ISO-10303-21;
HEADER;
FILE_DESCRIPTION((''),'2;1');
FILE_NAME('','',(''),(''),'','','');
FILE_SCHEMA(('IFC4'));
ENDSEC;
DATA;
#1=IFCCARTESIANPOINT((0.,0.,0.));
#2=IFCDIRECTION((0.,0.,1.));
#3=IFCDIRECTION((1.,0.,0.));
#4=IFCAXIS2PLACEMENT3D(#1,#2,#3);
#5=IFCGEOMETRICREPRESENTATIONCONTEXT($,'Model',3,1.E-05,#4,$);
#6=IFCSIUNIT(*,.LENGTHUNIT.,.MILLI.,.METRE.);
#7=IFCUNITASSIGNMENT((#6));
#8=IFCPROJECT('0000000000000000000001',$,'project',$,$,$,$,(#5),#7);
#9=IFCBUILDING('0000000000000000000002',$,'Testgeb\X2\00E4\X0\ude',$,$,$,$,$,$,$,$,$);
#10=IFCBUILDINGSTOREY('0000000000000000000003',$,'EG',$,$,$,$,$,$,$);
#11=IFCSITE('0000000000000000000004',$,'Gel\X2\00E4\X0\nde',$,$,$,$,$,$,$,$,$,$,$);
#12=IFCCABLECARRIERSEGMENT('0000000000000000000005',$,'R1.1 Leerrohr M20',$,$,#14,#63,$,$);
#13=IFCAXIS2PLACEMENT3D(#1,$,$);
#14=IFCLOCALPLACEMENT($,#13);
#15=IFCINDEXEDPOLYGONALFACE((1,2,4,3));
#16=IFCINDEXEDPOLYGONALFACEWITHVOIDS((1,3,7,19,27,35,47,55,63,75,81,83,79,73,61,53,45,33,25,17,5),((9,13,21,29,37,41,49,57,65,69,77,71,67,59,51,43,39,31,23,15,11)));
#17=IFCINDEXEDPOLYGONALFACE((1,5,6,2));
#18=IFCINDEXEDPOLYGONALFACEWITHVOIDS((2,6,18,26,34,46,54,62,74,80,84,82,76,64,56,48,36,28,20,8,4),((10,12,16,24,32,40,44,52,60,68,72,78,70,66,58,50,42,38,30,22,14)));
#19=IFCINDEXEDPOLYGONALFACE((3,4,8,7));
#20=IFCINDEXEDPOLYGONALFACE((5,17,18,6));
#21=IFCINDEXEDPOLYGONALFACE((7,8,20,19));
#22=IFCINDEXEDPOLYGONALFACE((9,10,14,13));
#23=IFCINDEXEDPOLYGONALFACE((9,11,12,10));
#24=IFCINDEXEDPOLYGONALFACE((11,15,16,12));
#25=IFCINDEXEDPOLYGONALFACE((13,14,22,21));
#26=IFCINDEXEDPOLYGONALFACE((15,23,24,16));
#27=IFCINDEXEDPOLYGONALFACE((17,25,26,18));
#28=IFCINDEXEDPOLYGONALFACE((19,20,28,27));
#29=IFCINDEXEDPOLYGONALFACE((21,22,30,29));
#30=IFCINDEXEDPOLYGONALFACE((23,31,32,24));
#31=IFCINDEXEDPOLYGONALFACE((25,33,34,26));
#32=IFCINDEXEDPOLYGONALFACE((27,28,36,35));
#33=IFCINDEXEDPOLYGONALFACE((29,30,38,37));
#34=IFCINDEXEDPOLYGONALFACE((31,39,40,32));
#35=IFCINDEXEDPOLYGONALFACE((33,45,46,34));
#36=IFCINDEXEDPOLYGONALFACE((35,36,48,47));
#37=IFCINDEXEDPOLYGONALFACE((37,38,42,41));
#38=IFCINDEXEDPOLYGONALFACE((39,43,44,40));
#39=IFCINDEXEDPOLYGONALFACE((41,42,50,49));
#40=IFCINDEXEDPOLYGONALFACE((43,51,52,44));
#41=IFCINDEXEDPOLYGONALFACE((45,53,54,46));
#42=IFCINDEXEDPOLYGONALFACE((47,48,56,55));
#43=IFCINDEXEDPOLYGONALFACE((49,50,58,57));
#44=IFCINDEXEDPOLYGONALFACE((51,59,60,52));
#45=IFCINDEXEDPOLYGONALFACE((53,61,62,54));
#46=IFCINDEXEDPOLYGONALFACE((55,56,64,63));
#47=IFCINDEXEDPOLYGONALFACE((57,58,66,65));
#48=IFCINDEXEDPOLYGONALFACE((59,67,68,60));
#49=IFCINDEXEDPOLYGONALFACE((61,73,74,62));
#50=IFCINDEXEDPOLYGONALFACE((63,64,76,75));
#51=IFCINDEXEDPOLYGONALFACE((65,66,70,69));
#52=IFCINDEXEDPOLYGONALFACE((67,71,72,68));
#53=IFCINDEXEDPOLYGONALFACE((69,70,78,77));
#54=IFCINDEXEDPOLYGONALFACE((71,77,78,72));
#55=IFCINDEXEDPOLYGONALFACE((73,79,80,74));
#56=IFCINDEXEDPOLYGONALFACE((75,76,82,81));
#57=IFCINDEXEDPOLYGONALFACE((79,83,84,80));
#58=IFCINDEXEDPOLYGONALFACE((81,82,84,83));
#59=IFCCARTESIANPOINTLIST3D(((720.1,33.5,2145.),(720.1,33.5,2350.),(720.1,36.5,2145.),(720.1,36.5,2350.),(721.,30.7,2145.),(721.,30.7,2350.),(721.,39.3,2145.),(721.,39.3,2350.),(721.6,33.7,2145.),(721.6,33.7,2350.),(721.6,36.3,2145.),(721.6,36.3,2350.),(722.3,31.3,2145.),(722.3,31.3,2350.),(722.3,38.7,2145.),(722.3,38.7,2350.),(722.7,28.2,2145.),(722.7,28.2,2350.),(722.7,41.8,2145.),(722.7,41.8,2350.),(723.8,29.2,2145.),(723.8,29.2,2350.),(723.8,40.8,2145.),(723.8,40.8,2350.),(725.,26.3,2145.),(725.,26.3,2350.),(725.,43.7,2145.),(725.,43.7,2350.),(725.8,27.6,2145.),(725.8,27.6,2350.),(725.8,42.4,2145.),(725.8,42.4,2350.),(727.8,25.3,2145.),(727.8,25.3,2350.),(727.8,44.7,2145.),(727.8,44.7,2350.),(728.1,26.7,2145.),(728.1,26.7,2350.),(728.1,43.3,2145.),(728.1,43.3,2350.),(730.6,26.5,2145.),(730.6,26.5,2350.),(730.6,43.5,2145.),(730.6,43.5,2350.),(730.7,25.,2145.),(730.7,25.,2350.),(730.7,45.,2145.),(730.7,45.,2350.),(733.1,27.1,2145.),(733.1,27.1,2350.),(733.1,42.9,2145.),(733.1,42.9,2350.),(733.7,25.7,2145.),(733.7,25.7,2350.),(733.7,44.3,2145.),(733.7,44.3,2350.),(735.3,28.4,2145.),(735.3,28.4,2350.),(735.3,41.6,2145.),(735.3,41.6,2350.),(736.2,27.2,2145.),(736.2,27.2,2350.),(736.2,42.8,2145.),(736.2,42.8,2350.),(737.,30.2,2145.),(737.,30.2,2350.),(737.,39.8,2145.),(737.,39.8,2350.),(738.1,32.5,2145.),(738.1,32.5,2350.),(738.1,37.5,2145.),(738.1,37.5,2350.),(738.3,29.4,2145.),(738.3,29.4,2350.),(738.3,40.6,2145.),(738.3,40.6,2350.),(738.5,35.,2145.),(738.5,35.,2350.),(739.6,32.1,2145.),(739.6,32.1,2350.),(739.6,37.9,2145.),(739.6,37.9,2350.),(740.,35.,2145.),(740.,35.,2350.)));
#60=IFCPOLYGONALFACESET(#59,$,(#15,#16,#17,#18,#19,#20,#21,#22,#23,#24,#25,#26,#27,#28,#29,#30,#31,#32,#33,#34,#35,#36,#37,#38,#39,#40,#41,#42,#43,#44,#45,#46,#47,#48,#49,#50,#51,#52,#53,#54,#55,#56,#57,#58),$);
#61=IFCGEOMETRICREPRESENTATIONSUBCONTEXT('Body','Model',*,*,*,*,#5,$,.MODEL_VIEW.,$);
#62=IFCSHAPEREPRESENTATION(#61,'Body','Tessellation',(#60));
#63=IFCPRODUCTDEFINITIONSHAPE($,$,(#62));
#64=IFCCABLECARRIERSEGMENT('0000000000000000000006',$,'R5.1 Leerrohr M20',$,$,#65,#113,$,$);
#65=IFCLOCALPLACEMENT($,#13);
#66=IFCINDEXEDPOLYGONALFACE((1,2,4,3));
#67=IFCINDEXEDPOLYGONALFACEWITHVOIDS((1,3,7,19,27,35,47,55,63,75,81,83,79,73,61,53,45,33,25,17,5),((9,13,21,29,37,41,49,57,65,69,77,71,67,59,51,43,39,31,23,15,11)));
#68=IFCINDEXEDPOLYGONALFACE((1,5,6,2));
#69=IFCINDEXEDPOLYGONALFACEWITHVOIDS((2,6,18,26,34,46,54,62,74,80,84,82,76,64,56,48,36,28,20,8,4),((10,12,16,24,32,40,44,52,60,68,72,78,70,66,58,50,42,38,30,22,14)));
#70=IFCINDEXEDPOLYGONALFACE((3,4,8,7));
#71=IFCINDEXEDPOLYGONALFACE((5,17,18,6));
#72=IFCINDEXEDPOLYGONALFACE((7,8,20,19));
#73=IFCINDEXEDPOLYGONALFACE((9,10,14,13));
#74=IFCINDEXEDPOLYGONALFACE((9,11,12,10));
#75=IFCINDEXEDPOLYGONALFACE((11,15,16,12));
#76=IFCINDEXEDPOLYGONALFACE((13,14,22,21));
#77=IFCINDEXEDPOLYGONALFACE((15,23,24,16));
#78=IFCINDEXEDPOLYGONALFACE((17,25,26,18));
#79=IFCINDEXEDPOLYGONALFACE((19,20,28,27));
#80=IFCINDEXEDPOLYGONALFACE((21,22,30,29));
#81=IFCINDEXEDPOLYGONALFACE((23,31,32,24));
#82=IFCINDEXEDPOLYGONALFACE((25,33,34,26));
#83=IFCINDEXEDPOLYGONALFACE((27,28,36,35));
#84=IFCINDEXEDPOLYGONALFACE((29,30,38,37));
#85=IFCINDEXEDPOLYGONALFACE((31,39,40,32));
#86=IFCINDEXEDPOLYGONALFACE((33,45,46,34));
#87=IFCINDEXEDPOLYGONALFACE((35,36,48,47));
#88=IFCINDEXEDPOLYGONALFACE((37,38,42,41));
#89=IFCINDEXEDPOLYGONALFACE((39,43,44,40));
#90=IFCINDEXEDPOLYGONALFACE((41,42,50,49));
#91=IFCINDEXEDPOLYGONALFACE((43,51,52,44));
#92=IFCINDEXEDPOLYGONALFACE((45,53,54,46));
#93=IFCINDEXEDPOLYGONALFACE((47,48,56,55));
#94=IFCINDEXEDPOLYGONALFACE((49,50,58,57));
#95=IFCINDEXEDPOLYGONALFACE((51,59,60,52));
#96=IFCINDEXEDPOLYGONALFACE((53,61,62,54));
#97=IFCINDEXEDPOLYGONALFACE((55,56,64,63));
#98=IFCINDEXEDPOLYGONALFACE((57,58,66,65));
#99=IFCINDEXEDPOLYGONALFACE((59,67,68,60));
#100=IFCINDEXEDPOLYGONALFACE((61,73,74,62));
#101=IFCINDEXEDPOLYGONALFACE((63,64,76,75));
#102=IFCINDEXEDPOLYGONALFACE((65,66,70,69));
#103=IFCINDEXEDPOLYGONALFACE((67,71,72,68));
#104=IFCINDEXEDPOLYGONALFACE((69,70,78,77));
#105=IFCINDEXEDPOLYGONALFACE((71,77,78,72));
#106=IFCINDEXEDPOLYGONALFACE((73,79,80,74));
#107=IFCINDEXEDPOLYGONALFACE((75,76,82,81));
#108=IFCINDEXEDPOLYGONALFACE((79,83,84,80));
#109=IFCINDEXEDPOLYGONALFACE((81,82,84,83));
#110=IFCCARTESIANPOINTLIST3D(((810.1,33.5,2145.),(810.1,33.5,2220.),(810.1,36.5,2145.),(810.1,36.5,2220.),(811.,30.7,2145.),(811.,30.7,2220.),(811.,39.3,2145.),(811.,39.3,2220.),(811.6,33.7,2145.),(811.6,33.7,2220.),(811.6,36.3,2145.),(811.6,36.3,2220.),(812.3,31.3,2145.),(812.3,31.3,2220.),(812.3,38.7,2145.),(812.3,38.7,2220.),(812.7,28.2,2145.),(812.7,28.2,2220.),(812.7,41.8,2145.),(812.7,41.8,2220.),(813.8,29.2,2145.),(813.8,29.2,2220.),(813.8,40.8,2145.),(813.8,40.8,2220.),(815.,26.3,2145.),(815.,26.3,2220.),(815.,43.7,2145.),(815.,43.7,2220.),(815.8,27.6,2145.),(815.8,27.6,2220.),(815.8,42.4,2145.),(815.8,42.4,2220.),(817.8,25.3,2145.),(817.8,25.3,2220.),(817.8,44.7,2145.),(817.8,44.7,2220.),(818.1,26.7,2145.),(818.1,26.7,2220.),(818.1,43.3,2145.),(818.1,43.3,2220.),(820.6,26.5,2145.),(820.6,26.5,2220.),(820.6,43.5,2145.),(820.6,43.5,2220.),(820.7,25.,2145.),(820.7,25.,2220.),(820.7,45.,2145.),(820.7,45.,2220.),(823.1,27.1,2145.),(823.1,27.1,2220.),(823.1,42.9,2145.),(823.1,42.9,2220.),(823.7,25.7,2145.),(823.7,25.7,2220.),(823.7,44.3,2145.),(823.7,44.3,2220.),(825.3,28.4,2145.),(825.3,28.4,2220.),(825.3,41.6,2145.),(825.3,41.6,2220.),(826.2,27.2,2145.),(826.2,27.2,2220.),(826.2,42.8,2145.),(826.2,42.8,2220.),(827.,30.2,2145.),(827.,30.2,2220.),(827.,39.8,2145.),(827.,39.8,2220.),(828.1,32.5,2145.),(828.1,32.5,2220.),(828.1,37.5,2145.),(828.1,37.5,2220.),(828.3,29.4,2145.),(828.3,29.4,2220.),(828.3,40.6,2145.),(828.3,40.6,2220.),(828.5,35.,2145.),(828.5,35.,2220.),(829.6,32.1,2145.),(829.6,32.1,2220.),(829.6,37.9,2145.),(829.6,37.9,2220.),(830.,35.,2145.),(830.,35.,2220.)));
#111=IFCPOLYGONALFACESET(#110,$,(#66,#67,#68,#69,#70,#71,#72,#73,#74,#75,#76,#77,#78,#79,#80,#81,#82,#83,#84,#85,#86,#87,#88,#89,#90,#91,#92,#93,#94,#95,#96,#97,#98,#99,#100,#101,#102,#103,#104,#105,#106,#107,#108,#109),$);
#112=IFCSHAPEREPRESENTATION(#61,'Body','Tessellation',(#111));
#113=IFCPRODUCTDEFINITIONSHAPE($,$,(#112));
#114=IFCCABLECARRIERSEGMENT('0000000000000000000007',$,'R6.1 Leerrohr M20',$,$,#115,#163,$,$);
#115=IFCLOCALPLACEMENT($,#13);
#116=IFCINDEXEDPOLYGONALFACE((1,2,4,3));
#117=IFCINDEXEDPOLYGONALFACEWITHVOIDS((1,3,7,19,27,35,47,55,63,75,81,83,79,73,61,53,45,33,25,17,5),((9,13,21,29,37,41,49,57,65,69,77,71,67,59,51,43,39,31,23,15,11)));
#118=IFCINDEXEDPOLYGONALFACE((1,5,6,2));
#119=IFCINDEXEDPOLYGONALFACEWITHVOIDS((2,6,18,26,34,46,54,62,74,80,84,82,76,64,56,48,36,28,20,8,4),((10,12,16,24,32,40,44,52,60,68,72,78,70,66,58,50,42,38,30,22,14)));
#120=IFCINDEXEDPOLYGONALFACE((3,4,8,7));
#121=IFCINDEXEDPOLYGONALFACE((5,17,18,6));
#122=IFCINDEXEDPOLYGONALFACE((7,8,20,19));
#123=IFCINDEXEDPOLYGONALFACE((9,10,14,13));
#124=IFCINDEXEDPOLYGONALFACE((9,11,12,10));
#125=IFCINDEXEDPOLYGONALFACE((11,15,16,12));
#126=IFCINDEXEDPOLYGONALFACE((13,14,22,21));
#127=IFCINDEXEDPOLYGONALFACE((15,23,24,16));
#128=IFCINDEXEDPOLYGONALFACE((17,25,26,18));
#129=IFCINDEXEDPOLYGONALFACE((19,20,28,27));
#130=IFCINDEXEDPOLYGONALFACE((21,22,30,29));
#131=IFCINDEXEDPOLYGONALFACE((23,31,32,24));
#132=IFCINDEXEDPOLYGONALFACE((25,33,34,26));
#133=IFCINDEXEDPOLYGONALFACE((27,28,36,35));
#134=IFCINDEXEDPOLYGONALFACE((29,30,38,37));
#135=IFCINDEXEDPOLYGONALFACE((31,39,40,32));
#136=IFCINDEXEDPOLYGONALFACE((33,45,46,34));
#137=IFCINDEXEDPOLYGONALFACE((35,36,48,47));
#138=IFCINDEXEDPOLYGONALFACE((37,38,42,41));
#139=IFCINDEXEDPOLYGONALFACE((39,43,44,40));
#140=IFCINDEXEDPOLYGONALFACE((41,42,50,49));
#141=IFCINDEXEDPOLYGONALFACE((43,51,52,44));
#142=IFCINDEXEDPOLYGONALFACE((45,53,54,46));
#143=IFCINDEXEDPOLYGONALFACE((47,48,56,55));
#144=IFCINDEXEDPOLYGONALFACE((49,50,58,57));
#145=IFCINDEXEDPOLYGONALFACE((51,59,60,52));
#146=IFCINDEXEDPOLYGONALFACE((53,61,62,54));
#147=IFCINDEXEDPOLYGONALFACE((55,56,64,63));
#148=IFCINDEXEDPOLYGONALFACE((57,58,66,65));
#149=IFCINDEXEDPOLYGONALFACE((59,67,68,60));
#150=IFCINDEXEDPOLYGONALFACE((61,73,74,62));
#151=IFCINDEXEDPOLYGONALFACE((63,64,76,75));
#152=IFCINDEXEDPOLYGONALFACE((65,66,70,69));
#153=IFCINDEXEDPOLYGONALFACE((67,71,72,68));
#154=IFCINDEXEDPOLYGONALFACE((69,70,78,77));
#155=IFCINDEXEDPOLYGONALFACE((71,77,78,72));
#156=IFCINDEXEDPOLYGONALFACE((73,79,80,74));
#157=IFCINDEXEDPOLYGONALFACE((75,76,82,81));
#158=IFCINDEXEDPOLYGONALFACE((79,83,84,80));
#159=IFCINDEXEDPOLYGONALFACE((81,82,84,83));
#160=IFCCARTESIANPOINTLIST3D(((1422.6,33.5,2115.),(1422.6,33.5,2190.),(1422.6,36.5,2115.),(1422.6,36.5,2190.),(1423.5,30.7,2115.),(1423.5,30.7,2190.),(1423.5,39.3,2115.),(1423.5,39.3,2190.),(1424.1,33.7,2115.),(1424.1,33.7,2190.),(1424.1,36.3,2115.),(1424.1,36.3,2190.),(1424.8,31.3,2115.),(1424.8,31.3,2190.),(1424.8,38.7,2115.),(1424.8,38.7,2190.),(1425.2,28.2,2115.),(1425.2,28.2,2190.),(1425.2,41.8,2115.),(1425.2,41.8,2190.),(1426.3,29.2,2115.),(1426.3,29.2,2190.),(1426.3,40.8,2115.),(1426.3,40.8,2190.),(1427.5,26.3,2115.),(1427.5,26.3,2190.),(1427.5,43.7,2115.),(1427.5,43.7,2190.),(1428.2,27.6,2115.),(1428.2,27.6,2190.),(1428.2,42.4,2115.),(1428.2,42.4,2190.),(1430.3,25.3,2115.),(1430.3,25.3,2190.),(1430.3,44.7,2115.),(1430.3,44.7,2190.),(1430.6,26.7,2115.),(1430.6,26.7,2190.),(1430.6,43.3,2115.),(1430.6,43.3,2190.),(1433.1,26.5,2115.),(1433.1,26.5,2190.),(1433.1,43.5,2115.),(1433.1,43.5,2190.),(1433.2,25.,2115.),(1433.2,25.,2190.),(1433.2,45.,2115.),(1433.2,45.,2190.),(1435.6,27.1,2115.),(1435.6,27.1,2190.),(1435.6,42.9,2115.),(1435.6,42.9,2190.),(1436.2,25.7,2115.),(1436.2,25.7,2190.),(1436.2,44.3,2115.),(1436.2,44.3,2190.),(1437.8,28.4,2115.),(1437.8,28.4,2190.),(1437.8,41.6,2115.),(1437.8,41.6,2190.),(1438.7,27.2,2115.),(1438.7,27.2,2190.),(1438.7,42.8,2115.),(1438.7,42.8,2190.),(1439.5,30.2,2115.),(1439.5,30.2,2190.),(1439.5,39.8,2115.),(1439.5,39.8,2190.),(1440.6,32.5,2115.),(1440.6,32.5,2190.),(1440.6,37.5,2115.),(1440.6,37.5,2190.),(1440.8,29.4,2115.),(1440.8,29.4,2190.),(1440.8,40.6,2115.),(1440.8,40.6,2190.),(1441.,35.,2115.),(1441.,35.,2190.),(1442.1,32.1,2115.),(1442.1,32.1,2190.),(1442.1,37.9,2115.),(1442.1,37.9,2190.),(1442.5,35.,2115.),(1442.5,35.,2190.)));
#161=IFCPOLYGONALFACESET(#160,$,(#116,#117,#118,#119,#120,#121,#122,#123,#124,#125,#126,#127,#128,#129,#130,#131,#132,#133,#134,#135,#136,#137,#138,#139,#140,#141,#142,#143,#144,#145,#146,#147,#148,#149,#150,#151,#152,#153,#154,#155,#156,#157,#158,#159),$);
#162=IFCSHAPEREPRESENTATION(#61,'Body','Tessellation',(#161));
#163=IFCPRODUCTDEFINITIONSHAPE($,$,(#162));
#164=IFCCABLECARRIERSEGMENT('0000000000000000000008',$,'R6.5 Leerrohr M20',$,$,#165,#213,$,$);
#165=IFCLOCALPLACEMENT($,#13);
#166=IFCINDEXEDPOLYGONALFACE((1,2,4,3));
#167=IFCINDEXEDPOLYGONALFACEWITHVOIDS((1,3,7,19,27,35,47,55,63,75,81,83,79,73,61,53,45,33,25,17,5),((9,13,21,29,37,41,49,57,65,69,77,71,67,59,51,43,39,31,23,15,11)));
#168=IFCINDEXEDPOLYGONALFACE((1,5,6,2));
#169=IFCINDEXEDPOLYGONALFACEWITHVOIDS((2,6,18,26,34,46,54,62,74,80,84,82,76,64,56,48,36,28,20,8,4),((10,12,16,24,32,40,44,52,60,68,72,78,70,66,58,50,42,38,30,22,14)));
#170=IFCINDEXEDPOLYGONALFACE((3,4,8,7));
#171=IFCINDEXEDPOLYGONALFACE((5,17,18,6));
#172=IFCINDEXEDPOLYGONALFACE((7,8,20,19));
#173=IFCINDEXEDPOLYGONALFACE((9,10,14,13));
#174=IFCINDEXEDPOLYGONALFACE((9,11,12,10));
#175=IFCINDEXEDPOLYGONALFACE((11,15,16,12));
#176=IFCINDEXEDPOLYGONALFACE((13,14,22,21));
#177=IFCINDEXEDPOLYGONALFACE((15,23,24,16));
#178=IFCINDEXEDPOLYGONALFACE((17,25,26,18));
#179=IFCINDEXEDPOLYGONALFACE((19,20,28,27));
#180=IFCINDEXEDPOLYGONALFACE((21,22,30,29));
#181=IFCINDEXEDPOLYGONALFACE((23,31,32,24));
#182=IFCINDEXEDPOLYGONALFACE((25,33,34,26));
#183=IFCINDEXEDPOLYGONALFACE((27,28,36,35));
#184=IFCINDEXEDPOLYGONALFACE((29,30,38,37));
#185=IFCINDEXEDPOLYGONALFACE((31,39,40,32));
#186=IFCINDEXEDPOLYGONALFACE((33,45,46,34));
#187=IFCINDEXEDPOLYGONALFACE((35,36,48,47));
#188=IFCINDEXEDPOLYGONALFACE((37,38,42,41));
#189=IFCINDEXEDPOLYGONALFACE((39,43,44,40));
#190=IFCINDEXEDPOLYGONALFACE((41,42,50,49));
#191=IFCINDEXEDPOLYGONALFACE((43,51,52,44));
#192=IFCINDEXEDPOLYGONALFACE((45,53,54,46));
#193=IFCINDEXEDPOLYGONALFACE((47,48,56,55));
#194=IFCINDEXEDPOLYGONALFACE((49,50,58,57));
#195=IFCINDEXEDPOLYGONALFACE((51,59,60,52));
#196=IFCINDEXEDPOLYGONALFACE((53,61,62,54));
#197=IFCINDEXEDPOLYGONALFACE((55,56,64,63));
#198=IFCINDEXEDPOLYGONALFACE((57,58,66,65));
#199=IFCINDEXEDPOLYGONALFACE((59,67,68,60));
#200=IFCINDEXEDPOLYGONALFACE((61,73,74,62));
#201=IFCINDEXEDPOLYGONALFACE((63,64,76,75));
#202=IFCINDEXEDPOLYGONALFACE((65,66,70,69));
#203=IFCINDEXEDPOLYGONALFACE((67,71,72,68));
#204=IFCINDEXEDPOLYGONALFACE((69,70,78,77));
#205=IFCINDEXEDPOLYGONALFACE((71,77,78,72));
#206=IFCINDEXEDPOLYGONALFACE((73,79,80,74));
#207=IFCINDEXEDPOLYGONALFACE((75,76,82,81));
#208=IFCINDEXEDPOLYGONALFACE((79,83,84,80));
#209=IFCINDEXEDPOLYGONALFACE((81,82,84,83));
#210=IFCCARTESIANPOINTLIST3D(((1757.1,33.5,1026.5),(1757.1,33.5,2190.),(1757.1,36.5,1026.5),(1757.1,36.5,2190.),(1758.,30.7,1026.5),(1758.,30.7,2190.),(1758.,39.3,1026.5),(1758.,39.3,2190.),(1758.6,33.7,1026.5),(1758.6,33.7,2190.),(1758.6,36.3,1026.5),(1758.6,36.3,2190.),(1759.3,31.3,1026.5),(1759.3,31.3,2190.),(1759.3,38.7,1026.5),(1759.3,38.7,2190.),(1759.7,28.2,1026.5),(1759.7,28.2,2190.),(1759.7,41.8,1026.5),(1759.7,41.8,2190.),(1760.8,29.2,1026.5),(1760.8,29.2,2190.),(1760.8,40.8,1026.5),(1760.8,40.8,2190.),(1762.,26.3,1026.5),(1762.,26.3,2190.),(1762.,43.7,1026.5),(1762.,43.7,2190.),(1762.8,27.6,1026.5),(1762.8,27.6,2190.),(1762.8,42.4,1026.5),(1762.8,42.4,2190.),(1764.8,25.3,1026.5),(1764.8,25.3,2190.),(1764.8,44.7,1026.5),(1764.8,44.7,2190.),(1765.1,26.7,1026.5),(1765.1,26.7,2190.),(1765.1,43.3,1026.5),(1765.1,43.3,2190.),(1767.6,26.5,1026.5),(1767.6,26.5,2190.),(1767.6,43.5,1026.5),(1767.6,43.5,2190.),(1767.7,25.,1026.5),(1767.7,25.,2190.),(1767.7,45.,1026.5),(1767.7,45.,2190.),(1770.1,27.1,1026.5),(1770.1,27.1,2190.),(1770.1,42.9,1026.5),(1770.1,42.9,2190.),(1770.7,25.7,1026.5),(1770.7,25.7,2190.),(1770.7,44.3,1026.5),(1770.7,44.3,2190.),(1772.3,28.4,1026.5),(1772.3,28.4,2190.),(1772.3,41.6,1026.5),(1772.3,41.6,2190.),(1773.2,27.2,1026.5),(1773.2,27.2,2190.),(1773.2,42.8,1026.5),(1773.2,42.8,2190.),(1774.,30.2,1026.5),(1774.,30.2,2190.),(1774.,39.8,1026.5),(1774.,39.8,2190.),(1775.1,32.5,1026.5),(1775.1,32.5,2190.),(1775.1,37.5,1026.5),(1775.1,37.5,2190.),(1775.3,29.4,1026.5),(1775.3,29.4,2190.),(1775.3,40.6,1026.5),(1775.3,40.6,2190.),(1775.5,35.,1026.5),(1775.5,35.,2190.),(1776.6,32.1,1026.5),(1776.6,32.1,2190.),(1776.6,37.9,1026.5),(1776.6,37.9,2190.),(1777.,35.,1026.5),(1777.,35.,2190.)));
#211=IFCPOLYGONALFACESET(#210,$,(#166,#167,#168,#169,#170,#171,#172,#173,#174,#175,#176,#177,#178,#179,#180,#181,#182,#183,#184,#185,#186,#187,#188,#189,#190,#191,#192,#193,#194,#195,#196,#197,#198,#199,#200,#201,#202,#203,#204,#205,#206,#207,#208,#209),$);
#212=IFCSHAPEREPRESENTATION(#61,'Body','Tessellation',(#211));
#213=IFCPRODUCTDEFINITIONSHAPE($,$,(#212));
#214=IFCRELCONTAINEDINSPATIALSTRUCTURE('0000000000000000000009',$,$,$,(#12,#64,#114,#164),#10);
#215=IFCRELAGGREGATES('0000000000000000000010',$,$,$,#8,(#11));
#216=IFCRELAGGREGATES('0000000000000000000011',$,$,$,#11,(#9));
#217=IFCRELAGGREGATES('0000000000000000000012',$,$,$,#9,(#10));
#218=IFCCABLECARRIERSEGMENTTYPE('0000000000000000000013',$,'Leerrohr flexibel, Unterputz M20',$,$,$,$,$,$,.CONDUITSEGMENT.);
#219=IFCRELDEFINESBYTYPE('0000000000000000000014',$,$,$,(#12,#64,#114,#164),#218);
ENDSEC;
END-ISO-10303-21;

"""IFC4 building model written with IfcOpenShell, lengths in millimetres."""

from ifc_helpers import new_model, si_unit, frame, origin_with_axes, place, context, subcontext, project, spatial, hollow_circle, extrude, type_object, element, save


model = new_model("IFC4")

# Units and contexts
model_context = context("Model", 3, precision=1e-05, world=origin_with_axes())
body_context = subcontext(model_context, "Body", "Model", "MODEL_VIEW")
ifc_project = project(units=[si_unit("LENGTHUNIT", "METRE", prefix="MILLI")], contexts=[model_context])

# Site, building, storey
site = spatial("IfcSite", under=ifc_project, Name="Gelände")
building = spatial("IfcBuilding", under=site, Name="Testgebäude")
storey = spatial("IfcBuildingStorey", under=building, Name="EG")

# Cable carrier segments
cable_carrier_segment_type_1 = type_object("IfcCableCarrierSegmentType", Name="Leerrohr flexibel, Unterputz M20", PredefinedType="CONDUITSEGMENT")
cable_carrier_segment_1_placement = place(None, frame((730.0, 35.0, 2145.0), z_axis=(0.0, 0.0, 1.0), x_axis=(1.0, 0.0, 0.0)))
element("IfcCableCarrierSegment", 1, at=cable_carrier_segment_1_placement, inside=storey, type_object=cable_carrier_segment_type_1, Name="R1.1 Leerrohr M20", context=body_context, shape_type="SweptSolid", body=[
    extrude(hollow_circle(Radius=10.0, WallThickness=1.5), None, (0.0, 0.0, 1.0), 205.0),
])
for number, where, z_axis, x_axis, name in (
    (2, (820.0, 35.0, 2145.0), (0.0, 0.0, 1.0), (1.0, 0.0, 0.0), "R5.1 Leerrohr M20"),
    (3, (1432.5, 35.0, 2115.0), (0.0, 0.0, 1.0), (1.0, 0.0, 0.0), "R6.1 Leerrohr M20"),
):
    element("IfcCableCarrierSegment", number, at=place(None, frame(where, z_axis=z_axis, x_axis=x_axis)), inside=storey, type_object=cable_carrier_segment_type_1, Name=name, context=body_context, shape_type="SweptSolid", body=[
        extrude(hollow_circle(Radius=10.0, WallThickness=1.5), None, (0.0, 0.0, 1.0), 75.0),
    ])
cable_carrier_segment_2_placement = place(None, frame((1767.0, 35.0, 2190.0), z_axis=(0.0, 0.0, -1.0), x_axis=(1.0, 0.0, 0.0)))
element("IfcCableCarrierSegment", 4, at=cable_carrier_segment_2_placement, inside=storey, type_object=cable_carrier_segment_type_1, Name="R6.5 Leerrohr M20", context=body_context, shape_type="SweptSolid", body=[
    extrude(hollow_circle(Radius=10.0, WallThickness=1.5), None, (0.0, 0.0, 1.0), 1163.5),
])

save(model, "model.ifc")
